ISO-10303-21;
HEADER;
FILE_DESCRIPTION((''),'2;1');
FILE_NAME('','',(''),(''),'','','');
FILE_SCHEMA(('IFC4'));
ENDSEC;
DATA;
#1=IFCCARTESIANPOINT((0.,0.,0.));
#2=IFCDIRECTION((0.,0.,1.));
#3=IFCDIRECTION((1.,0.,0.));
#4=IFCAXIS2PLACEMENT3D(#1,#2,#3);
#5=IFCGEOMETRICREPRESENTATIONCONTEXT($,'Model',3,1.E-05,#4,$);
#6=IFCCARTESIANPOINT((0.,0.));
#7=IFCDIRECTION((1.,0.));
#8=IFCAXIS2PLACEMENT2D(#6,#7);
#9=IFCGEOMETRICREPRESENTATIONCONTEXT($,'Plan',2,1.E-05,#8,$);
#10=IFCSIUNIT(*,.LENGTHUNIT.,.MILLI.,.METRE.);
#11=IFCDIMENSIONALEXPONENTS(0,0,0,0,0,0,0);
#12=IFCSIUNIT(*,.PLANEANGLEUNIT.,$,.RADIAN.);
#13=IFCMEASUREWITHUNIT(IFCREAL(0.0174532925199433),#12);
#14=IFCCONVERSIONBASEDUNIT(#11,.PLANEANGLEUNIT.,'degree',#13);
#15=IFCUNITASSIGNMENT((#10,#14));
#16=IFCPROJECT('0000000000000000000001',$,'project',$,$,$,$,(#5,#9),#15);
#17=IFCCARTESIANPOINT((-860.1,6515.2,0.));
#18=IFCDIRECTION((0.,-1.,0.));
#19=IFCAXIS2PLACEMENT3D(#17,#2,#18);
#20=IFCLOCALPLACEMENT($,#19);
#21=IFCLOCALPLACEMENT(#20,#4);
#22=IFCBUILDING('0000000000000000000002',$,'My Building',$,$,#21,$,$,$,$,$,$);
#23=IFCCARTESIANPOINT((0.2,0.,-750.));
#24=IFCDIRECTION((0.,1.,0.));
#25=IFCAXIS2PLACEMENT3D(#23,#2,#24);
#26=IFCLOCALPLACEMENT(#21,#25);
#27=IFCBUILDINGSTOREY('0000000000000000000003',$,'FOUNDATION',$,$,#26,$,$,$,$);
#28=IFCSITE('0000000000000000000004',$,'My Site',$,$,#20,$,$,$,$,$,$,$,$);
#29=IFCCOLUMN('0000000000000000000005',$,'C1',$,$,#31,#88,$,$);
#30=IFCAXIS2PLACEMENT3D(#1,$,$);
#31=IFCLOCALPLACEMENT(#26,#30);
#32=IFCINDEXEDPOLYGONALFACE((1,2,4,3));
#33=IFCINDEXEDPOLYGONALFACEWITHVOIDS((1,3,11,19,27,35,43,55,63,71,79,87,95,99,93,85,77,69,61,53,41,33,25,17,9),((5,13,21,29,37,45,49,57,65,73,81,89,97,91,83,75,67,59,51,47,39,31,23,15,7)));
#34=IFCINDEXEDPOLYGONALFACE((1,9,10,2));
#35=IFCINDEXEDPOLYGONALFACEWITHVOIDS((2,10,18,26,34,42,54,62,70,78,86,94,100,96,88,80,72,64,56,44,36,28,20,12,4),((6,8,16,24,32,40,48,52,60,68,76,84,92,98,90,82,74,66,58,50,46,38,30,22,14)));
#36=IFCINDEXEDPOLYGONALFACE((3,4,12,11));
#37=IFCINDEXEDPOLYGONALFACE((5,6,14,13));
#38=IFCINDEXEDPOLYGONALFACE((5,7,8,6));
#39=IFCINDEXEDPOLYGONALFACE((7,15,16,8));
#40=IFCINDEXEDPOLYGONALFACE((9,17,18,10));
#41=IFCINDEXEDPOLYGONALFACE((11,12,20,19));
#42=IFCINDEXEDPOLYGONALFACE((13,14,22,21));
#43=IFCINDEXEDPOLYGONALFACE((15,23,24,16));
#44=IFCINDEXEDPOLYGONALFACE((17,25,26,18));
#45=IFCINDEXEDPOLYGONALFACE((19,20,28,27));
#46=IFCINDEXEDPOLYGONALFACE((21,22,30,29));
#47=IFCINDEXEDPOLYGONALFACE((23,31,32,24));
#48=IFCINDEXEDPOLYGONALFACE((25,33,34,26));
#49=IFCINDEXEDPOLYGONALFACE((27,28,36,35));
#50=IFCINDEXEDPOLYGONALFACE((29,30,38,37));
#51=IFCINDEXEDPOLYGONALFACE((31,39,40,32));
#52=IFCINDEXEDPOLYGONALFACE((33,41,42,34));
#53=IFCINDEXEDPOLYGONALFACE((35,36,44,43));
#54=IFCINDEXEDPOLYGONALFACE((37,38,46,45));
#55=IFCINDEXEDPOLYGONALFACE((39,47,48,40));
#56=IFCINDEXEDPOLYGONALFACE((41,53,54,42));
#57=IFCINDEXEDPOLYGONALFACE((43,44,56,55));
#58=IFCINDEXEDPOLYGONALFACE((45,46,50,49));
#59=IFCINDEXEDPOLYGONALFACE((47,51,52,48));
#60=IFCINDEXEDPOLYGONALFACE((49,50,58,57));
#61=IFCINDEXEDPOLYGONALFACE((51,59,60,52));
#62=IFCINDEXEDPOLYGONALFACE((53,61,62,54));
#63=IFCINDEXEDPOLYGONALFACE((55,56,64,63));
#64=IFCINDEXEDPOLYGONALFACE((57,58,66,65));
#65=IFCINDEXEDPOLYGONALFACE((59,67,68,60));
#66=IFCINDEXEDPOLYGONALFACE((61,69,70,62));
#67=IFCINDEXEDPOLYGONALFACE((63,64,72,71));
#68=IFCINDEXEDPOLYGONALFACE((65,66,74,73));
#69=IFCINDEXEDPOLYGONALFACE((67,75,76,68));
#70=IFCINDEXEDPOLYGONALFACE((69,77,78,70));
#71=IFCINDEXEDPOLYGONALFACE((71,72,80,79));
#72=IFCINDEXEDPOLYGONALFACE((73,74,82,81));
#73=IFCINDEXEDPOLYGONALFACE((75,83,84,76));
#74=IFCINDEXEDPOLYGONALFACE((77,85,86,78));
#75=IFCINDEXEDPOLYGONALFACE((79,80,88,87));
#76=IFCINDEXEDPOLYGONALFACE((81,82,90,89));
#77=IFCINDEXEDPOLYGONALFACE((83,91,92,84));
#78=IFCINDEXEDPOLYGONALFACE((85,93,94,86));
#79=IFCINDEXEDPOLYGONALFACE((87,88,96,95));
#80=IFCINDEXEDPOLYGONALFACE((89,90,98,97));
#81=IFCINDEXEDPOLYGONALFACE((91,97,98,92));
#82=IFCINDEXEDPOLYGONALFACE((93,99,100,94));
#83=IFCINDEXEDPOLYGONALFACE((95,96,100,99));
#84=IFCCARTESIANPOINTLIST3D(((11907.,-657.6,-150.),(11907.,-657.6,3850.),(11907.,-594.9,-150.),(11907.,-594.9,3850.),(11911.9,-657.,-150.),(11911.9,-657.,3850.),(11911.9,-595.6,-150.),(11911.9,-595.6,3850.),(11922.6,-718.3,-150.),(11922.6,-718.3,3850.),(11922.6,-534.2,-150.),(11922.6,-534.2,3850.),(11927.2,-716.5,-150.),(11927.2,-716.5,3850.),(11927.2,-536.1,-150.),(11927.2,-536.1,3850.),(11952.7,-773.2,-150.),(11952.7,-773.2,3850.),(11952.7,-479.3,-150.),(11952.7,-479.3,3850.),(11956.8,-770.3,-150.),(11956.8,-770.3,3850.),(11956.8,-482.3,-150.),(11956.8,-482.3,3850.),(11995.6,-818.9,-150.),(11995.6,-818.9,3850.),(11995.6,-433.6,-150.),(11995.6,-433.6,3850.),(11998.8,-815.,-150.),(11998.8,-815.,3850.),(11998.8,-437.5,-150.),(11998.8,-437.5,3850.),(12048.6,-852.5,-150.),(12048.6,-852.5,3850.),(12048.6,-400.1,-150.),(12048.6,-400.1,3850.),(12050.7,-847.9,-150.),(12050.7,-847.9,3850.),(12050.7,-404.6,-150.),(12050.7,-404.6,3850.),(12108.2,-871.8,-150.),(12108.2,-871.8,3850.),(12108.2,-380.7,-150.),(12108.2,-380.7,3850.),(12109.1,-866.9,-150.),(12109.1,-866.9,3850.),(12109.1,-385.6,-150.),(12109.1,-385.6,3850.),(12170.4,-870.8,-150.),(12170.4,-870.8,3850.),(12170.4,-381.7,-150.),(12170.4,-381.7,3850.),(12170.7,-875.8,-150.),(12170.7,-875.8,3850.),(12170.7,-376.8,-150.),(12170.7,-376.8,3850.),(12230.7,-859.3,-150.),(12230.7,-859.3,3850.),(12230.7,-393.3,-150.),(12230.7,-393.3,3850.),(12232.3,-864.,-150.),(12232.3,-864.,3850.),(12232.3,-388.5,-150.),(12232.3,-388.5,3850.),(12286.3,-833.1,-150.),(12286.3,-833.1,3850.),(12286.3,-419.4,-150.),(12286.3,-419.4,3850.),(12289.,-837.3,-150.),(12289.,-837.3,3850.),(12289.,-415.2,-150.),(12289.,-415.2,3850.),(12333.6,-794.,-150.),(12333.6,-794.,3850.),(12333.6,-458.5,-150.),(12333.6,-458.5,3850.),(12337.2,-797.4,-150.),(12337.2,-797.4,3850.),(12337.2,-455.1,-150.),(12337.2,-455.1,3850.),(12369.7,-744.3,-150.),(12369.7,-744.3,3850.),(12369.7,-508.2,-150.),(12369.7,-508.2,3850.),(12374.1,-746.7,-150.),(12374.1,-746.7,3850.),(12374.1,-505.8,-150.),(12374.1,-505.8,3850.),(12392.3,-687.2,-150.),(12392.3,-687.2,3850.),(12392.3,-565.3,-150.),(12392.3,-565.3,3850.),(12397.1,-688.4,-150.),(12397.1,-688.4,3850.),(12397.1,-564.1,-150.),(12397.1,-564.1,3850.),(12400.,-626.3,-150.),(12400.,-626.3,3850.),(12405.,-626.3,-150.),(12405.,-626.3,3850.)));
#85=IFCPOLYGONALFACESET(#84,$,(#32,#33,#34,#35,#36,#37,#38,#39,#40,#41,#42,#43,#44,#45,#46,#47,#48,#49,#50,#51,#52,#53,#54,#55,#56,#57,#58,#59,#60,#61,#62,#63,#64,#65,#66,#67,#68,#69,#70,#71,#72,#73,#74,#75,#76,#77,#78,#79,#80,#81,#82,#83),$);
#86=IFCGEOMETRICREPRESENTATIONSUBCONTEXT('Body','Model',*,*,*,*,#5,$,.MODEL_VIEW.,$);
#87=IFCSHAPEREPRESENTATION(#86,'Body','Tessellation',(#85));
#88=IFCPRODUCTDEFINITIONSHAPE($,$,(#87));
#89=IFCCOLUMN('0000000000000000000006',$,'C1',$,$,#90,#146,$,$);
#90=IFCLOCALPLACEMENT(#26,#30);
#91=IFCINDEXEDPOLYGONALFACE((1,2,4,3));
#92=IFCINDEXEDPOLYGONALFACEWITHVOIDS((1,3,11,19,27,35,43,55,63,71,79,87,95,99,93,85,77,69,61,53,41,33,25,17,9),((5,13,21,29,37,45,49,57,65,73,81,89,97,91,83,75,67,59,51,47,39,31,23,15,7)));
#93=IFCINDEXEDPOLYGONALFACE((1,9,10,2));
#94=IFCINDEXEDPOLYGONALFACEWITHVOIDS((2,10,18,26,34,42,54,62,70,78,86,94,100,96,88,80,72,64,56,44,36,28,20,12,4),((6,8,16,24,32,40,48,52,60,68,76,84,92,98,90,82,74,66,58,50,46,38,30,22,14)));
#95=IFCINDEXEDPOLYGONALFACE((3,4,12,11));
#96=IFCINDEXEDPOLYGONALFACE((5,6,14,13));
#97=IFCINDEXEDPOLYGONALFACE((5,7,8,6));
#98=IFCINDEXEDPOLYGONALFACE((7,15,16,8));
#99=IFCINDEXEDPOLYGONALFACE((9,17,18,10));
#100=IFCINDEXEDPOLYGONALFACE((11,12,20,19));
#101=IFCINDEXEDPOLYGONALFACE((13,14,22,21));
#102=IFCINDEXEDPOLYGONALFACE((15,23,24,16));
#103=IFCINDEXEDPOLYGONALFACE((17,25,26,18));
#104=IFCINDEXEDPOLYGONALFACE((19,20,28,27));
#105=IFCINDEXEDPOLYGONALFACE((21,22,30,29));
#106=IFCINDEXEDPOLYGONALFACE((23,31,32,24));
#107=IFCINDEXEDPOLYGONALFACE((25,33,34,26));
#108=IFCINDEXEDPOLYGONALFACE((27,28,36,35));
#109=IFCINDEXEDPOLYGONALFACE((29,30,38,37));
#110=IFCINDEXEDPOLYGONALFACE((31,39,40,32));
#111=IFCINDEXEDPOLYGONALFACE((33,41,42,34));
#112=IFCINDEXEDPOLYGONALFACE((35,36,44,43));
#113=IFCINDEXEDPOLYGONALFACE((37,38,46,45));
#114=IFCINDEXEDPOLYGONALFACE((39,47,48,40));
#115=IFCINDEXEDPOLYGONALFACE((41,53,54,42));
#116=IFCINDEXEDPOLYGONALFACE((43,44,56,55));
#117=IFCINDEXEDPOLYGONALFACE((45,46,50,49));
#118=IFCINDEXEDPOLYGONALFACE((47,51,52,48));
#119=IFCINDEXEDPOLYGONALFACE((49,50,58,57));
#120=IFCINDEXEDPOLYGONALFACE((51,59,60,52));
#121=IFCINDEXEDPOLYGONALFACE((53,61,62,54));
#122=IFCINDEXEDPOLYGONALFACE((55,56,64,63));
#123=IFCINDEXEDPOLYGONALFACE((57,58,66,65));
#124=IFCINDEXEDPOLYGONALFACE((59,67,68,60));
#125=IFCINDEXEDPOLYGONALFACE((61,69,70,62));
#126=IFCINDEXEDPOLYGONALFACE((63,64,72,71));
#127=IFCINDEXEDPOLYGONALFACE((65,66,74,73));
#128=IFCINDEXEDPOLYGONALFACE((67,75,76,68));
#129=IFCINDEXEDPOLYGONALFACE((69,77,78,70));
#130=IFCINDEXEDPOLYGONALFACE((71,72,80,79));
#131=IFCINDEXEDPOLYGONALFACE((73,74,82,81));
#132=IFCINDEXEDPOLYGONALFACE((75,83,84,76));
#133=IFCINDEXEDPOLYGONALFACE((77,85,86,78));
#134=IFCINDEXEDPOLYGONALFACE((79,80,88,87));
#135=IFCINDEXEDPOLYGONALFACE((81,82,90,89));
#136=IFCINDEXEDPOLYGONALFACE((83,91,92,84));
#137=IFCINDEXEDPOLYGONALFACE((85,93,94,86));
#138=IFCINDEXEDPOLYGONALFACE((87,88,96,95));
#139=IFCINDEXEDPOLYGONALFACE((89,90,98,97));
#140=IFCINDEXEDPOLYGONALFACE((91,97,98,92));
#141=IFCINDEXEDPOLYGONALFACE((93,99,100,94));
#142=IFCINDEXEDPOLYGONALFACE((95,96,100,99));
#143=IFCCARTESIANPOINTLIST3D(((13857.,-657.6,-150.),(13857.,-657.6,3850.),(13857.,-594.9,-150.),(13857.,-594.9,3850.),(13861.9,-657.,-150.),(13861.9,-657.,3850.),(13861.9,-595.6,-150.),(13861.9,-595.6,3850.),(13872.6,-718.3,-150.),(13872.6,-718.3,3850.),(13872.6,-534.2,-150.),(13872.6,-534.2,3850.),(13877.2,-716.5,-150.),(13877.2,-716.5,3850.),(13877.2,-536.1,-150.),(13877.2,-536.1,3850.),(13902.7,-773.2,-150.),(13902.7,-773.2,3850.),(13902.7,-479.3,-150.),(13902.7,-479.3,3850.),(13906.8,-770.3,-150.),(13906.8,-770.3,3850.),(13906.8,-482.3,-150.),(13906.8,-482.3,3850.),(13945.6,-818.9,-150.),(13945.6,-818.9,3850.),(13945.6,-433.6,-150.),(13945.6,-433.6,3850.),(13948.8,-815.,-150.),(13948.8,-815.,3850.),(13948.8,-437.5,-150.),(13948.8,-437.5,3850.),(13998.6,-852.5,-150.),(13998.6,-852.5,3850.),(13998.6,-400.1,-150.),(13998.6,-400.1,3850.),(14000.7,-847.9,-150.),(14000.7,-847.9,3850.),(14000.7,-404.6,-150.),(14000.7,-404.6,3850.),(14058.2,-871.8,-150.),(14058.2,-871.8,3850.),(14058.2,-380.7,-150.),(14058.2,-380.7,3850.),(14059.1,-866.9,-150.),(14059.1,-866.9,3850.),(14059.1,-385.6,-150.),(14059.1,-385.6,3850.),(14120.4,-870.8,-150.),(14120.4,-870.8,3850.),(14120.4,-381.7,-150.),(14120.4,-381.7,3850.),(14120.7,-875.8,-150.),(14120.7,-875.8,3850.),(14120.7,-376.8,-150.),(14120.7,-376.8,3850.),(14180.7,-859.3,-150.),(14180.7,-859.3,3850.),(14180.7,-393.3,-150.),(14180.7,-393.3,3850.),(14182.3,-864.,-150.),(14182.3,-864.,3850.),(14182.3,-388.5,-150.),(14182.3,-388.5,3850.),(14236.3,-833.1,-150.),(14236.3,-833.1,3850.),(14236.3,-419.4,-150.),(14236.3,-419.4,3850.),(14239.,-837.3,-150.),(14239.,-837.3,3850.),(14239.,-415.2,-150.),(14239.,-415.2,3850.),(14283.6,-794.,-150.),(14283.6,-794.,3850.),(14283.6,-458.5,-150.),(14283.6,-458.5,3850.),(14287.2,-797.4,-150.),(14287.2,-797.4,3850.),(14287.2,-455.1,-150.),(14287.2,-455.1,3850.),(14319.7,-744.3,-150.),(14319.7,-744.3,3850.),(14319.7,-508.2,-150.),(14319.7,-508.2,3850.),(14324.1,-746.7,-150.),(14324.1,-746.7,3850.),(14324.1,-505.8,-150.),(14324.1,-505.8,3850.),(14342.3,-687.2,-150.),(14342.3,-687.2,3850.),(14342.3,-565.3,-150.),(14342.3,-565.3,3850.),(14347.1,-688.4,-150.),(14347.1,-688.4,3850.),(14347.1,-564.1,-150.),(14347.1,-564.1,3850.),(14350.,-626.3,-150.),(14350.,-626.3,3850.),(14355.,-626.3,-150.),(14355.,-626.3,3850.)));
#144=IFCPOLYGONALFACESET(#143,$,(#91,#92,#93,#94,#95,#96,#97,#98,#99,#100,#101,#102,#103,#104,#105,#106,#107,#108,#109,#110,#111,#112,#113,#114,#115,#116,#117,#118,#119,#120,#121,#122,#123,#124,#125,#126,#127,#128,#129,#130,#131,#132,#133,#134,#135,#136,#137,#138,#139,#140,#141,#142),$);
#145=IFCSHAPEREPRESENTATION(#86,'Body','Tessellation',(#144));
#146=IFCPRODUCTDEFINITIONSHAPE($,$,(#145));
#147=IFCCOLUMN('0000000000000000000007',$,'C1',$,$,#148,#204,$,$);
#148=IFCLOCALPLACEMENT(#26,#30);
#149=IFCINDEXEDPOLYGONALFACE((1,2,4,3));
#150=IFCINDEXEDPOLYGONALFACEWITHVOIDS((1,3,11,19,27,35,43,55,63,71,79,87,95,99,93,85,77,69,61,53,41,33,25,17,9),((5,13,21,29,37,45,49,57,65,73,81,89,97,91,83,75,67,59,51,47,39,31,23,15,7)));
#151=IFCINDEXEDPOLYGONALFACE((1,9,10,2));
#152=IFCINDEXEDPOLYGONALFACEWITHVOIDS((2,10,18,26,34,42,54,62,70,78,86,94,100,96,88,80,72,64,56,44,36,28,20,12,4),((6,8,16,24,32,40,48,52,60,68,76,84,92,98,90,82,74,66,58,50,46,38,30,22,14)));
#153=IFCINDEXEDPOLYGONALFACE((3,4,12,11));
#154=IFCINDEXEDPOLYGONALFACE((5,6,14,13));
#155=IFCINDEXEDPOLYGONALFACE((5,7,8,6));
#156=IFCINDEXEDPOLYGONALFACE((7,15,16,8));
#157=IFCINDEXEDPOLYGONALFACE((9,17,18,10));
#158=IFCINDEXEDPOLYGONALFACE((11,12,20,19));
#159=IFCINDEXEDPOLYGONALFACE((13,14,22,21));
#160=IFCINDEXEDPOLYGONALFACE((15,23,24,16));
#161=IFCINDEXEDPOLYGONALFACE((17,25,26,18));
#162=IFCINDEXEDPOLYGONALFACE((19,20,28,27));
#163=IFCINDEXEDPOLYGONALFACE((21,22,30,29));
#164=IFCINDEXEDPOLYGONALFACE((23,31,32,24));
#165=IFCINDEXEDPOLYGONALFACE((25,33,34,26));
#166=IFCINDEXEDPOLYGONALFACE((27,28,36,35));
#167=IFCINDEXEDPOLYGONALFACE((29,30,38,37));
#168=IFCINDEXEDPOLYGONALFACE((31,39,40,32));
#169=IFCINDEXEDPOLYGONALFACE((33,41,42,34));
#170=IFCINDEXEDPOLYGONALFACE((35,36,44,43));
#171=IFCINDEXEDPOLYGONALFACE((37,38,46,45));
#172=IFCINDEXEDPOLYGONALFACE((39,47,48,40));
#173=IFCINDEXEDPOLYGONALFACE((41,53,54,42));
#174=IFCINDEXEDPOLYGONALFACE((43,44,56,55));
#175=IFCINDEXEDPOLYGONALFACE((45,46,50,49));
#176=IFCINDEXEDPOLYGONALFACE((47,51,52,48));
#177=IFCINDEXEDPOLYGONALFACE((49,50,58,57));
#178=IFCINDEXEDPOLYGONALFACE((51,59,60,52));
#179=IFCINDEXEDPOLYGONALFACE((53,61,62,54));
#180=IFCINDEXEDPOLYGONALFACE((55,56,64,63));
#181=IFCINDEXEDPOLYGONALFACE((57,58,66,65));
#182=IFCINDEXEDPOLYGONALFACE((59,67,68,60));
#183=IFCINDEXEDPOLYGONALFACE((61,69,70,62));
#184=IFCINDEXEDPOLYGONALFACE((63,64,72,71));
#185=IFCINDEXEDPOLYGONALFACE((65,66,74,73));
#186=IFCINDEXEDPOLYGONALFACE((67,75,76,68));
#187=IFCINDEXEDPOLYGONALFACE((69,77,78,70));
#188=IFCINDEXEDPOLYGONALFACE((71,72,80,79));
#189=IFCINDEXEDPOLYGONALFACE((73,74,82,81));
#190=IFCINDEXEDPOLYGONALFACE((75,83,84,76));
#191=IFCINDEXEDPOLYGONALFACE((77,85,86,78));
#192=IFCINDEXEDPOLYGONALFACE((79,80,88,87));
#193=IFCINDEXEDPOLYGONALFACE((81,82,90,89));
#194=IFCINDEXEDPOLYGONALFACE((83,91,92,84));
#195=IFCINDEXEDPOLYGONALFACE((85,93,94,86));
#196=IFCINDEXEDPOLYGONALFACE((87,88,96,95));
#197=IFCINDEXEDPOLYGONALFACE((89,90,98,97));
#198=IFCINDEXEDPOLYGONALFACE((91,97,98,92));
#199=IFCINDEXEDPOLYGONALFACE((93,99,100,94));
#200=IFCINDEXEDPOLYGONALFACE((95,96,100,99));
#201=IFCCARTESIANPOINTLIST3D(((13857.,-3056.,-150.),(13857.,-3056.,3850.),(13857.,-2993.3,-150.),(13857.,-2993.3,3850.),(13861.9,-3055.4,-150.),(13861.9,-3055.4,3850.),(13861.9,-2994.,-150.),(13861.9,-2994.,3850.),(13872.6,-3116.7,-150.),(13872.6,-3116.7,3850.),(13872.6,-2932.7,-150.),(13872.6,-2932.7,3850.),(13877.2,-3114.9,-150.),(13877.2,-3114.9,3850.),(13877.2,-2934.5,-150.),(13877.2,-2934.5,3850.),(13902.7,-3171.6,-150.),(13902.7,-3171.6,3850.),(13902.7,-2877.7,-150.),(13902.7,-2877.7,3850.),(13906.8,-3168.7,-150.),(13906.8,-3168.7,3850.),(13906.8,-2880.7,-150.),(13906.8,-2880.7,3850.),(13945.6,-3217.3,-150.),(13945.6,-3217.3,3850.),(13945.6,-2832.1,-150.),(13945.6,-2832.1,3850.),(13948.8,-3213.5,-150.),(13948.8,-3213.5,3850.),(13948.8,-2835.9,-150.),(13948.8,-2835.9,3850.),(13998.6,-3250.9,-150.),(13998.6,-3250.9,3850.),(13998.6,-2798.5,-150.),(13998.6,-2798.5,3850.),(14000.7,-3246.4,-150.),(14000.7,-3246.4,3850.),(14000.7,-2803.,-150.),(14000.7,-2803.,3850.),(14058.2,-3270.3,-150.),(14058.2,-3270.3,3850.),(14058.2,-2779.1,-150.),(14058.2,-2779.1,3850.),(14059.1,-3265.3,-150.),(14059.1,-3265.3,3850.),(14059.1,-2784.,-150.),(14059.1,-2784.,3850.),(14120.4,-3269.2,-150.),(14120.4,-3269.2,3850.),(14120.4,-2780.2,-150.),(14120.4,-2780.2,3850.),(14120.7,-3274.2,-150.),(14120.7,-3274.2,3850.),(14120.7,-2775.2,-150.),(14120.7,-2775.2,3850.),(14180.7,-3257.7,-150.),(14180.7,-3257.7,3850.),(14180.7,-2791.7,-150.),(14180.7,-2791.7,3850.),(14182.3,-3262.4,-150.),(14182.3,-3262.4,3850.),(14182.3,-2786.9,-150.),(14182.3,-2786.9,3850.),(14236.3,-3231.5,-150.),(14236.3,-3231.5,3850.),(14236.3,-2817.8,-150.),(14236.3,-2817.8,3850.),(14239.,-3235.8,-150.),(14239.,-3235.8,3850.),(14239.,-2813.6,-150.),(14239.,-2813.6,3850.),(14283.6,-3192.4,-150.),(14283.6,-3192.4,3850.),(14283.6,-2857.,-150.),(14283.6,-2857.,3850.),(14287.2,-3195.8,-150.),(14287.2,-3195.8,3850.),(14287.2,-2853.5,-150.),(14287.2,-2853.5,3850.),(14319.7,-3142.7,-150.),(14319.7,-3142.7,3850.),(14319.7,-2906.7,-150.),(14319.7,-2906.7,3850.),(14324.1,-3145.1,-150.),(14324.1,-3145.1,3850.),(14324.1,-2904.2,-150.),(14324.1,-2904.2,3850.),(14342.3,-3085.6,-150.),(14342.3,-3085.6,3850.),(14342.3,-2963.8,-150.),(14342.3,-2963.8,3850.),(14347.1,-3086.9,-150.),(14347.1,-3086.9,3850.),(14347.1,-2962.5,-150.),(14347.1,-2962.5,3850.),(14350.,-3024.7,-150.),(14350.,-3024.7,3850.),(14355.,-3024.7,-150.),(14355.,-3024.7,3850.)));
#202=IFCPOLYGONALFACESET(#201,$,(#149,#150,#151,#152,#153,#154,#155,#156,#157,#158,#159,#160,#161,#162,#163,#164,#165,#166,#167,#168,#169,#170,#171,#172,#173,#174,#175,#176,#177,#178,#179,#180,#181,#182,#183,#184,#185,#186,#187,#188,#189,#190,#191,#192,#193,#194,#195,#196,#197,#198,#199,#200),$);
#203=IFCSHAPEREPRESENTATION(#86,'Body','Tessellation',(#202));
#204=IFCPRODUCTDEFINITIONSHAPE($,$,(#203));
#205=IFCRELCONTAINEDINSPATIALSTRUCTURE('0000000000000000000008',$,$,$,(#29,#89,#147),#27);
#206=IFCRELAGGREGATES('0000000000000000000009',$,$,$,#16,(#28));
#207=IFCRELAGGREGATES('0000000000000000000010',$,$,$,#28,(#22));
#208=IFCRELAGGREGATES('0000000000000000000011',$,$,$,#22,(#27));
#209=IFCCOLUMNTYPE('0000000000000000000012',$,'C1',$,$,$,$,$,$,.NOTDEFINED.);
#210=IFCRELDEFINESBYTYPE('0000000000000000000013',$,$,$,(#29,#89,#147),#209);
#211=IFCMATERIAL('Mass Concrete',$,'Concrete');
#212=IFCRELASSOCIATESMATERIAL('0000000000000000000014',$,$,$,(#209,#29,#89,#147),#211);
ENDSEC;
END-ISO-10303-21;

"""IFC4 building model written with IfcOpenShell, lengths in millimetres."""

from ifc_helpers import new_model, entity, si_unit, converted_unit, frame, origin_with_axes, origin_2d_with_axis, place, context, subcontext, project, spatial, rectangle, hollow_circle, extrude, material, material_profile, profile_set, profile_usage, type_object, element, save


model = new_model("IFC4")

# Units and contexts
model_context = context("Model", 3, precision=1e-05, world=origin_with_axes())
plan_context = context("Plan", 2, precision=1e-05, world=origin_2d_with_axis())
body_context = subcontext(model_context, "Body", "Model", "MODEL_VIEW")
ifc_project = project(units=[si_unit("LENGTHUNIT", "METRE", prefix="MILLI"), converted_unit("PLANEANGLEUNIT", "degree", entity("IfcReal", 0.0174532925199433), si_unit("PLANEANGLEUNIT", "RADIAN"), dimensions=[0, 0, 0, 0, 0, 0, 0])], contexts=[model_context, plan_context])

# Site, building, storey
site_placement = place(None, frame((-860.1, 6515.2, 0.0), z_axis=(0.0, 0.0, 1.0), x_axis=(0.0, -1.0, 0.0)))
site = spatial("IfcSite", under=ifc_project, at=site_placement, Name="My Site")
building_placement = place(site_placement, frame((0.0, 0.0, 0.0), z_axis=(0.0, 0.0, 1.0), x_axis=(1.0, 0.0, 0.0)))
building = spatial("IfcBuilding", under=site, at=building_placement, Name="My Building")
storey_placement = place(building_placement, frame((0.2, 0.0, -750.0), z_axis=(0.0, 0.0, 1.0), x_axis=(0.0, 1.0, 0.0)))
storey = spatial("IfcBuildingStorey", under=building, at=storey_placement, Name="FOUNDATION")

# Shared definitions
ifc_material_1 = material(Name="Mass Concrete", Category="Concrete")

# Columns
ifc_material_profile = material_profile(ifc_material_1, rectangle(XDim=150.0, YDim=150.0), Name="Square Column", Category="Structure", Priority=1)
ifc_profile_set = profile_set([ifc_material_profile], Name="RC_COL_150x150")
column_type = type_object("IfcColumnType", Name="C1", PredefinedType="NOTDEFINED", material=ifc_profile_set)
ifc_profile_usage_1 = profile_usage(ifc_profile_set, cardinal=5)
column_1_placement = place(storey_placement, frame((12155.0, -626.3, -150.0), z_axis=(0.0, 0.0, 1.0), x_axis=(1.0, 0.0, 0.0)))
element("IfcColumn", 1, at=column_1_placement, inside=storey, type_object=column_type, material=ifc_profile_usage_1, Name="C1", context=body_context, shape_type="SweptSolid", body=[
    extrude(hollow_circle(Radius=250.0, WallThickness=5.0), origin_with_axes(), (0.0, 0.0, 1.0), 4000.0),
])
ifc_profile_usage_2 = profile_usage(ifc_profile_set, cardinal=5)
column_2_placement = place(storey_placement, frame((14105.0, -626.3, -150.0), z_axis=(0.0, 0.0, 1.0), x_axis=(1.0, 0.0, 0.0)))
element("IfcColumn", 2, at=column_2_placement, inside=storey, type_object=column_type, material=ifc_profile_usage_2, Name="C1", context=body_context, shape_type="SweptSolid", body=[
    extrude(hollow_circle(Radius=250.0, WallThickness=5.0), origin_with_axes(), (0.0, 0.0, 1.0), 4000.0),
])
ifc_profile_usage_3 = profile_usage(ifc_profile_set, cardinal=5)
column_3_placement = place(storey_placement, frame((14105.0, -3024.7, -150.0), z_axis=(0.0, 0.0, 1.0), x_axis=(1.0, 0.0, 0.0)))
element("IfcColumn", 3, at=column_3_placement, inside=storey, type_object=column_type, material=ifc_profile_usage_3, Name="C1", context=body_context, shape_type="SweptSolid", body=[
    extrude(hollow_circle(Radius=250.0, WallThickness=5.0), origin_with_axes(), (0.0, 0.0, 1.0), 4000.0),
])

save(model, "model.ifc")
